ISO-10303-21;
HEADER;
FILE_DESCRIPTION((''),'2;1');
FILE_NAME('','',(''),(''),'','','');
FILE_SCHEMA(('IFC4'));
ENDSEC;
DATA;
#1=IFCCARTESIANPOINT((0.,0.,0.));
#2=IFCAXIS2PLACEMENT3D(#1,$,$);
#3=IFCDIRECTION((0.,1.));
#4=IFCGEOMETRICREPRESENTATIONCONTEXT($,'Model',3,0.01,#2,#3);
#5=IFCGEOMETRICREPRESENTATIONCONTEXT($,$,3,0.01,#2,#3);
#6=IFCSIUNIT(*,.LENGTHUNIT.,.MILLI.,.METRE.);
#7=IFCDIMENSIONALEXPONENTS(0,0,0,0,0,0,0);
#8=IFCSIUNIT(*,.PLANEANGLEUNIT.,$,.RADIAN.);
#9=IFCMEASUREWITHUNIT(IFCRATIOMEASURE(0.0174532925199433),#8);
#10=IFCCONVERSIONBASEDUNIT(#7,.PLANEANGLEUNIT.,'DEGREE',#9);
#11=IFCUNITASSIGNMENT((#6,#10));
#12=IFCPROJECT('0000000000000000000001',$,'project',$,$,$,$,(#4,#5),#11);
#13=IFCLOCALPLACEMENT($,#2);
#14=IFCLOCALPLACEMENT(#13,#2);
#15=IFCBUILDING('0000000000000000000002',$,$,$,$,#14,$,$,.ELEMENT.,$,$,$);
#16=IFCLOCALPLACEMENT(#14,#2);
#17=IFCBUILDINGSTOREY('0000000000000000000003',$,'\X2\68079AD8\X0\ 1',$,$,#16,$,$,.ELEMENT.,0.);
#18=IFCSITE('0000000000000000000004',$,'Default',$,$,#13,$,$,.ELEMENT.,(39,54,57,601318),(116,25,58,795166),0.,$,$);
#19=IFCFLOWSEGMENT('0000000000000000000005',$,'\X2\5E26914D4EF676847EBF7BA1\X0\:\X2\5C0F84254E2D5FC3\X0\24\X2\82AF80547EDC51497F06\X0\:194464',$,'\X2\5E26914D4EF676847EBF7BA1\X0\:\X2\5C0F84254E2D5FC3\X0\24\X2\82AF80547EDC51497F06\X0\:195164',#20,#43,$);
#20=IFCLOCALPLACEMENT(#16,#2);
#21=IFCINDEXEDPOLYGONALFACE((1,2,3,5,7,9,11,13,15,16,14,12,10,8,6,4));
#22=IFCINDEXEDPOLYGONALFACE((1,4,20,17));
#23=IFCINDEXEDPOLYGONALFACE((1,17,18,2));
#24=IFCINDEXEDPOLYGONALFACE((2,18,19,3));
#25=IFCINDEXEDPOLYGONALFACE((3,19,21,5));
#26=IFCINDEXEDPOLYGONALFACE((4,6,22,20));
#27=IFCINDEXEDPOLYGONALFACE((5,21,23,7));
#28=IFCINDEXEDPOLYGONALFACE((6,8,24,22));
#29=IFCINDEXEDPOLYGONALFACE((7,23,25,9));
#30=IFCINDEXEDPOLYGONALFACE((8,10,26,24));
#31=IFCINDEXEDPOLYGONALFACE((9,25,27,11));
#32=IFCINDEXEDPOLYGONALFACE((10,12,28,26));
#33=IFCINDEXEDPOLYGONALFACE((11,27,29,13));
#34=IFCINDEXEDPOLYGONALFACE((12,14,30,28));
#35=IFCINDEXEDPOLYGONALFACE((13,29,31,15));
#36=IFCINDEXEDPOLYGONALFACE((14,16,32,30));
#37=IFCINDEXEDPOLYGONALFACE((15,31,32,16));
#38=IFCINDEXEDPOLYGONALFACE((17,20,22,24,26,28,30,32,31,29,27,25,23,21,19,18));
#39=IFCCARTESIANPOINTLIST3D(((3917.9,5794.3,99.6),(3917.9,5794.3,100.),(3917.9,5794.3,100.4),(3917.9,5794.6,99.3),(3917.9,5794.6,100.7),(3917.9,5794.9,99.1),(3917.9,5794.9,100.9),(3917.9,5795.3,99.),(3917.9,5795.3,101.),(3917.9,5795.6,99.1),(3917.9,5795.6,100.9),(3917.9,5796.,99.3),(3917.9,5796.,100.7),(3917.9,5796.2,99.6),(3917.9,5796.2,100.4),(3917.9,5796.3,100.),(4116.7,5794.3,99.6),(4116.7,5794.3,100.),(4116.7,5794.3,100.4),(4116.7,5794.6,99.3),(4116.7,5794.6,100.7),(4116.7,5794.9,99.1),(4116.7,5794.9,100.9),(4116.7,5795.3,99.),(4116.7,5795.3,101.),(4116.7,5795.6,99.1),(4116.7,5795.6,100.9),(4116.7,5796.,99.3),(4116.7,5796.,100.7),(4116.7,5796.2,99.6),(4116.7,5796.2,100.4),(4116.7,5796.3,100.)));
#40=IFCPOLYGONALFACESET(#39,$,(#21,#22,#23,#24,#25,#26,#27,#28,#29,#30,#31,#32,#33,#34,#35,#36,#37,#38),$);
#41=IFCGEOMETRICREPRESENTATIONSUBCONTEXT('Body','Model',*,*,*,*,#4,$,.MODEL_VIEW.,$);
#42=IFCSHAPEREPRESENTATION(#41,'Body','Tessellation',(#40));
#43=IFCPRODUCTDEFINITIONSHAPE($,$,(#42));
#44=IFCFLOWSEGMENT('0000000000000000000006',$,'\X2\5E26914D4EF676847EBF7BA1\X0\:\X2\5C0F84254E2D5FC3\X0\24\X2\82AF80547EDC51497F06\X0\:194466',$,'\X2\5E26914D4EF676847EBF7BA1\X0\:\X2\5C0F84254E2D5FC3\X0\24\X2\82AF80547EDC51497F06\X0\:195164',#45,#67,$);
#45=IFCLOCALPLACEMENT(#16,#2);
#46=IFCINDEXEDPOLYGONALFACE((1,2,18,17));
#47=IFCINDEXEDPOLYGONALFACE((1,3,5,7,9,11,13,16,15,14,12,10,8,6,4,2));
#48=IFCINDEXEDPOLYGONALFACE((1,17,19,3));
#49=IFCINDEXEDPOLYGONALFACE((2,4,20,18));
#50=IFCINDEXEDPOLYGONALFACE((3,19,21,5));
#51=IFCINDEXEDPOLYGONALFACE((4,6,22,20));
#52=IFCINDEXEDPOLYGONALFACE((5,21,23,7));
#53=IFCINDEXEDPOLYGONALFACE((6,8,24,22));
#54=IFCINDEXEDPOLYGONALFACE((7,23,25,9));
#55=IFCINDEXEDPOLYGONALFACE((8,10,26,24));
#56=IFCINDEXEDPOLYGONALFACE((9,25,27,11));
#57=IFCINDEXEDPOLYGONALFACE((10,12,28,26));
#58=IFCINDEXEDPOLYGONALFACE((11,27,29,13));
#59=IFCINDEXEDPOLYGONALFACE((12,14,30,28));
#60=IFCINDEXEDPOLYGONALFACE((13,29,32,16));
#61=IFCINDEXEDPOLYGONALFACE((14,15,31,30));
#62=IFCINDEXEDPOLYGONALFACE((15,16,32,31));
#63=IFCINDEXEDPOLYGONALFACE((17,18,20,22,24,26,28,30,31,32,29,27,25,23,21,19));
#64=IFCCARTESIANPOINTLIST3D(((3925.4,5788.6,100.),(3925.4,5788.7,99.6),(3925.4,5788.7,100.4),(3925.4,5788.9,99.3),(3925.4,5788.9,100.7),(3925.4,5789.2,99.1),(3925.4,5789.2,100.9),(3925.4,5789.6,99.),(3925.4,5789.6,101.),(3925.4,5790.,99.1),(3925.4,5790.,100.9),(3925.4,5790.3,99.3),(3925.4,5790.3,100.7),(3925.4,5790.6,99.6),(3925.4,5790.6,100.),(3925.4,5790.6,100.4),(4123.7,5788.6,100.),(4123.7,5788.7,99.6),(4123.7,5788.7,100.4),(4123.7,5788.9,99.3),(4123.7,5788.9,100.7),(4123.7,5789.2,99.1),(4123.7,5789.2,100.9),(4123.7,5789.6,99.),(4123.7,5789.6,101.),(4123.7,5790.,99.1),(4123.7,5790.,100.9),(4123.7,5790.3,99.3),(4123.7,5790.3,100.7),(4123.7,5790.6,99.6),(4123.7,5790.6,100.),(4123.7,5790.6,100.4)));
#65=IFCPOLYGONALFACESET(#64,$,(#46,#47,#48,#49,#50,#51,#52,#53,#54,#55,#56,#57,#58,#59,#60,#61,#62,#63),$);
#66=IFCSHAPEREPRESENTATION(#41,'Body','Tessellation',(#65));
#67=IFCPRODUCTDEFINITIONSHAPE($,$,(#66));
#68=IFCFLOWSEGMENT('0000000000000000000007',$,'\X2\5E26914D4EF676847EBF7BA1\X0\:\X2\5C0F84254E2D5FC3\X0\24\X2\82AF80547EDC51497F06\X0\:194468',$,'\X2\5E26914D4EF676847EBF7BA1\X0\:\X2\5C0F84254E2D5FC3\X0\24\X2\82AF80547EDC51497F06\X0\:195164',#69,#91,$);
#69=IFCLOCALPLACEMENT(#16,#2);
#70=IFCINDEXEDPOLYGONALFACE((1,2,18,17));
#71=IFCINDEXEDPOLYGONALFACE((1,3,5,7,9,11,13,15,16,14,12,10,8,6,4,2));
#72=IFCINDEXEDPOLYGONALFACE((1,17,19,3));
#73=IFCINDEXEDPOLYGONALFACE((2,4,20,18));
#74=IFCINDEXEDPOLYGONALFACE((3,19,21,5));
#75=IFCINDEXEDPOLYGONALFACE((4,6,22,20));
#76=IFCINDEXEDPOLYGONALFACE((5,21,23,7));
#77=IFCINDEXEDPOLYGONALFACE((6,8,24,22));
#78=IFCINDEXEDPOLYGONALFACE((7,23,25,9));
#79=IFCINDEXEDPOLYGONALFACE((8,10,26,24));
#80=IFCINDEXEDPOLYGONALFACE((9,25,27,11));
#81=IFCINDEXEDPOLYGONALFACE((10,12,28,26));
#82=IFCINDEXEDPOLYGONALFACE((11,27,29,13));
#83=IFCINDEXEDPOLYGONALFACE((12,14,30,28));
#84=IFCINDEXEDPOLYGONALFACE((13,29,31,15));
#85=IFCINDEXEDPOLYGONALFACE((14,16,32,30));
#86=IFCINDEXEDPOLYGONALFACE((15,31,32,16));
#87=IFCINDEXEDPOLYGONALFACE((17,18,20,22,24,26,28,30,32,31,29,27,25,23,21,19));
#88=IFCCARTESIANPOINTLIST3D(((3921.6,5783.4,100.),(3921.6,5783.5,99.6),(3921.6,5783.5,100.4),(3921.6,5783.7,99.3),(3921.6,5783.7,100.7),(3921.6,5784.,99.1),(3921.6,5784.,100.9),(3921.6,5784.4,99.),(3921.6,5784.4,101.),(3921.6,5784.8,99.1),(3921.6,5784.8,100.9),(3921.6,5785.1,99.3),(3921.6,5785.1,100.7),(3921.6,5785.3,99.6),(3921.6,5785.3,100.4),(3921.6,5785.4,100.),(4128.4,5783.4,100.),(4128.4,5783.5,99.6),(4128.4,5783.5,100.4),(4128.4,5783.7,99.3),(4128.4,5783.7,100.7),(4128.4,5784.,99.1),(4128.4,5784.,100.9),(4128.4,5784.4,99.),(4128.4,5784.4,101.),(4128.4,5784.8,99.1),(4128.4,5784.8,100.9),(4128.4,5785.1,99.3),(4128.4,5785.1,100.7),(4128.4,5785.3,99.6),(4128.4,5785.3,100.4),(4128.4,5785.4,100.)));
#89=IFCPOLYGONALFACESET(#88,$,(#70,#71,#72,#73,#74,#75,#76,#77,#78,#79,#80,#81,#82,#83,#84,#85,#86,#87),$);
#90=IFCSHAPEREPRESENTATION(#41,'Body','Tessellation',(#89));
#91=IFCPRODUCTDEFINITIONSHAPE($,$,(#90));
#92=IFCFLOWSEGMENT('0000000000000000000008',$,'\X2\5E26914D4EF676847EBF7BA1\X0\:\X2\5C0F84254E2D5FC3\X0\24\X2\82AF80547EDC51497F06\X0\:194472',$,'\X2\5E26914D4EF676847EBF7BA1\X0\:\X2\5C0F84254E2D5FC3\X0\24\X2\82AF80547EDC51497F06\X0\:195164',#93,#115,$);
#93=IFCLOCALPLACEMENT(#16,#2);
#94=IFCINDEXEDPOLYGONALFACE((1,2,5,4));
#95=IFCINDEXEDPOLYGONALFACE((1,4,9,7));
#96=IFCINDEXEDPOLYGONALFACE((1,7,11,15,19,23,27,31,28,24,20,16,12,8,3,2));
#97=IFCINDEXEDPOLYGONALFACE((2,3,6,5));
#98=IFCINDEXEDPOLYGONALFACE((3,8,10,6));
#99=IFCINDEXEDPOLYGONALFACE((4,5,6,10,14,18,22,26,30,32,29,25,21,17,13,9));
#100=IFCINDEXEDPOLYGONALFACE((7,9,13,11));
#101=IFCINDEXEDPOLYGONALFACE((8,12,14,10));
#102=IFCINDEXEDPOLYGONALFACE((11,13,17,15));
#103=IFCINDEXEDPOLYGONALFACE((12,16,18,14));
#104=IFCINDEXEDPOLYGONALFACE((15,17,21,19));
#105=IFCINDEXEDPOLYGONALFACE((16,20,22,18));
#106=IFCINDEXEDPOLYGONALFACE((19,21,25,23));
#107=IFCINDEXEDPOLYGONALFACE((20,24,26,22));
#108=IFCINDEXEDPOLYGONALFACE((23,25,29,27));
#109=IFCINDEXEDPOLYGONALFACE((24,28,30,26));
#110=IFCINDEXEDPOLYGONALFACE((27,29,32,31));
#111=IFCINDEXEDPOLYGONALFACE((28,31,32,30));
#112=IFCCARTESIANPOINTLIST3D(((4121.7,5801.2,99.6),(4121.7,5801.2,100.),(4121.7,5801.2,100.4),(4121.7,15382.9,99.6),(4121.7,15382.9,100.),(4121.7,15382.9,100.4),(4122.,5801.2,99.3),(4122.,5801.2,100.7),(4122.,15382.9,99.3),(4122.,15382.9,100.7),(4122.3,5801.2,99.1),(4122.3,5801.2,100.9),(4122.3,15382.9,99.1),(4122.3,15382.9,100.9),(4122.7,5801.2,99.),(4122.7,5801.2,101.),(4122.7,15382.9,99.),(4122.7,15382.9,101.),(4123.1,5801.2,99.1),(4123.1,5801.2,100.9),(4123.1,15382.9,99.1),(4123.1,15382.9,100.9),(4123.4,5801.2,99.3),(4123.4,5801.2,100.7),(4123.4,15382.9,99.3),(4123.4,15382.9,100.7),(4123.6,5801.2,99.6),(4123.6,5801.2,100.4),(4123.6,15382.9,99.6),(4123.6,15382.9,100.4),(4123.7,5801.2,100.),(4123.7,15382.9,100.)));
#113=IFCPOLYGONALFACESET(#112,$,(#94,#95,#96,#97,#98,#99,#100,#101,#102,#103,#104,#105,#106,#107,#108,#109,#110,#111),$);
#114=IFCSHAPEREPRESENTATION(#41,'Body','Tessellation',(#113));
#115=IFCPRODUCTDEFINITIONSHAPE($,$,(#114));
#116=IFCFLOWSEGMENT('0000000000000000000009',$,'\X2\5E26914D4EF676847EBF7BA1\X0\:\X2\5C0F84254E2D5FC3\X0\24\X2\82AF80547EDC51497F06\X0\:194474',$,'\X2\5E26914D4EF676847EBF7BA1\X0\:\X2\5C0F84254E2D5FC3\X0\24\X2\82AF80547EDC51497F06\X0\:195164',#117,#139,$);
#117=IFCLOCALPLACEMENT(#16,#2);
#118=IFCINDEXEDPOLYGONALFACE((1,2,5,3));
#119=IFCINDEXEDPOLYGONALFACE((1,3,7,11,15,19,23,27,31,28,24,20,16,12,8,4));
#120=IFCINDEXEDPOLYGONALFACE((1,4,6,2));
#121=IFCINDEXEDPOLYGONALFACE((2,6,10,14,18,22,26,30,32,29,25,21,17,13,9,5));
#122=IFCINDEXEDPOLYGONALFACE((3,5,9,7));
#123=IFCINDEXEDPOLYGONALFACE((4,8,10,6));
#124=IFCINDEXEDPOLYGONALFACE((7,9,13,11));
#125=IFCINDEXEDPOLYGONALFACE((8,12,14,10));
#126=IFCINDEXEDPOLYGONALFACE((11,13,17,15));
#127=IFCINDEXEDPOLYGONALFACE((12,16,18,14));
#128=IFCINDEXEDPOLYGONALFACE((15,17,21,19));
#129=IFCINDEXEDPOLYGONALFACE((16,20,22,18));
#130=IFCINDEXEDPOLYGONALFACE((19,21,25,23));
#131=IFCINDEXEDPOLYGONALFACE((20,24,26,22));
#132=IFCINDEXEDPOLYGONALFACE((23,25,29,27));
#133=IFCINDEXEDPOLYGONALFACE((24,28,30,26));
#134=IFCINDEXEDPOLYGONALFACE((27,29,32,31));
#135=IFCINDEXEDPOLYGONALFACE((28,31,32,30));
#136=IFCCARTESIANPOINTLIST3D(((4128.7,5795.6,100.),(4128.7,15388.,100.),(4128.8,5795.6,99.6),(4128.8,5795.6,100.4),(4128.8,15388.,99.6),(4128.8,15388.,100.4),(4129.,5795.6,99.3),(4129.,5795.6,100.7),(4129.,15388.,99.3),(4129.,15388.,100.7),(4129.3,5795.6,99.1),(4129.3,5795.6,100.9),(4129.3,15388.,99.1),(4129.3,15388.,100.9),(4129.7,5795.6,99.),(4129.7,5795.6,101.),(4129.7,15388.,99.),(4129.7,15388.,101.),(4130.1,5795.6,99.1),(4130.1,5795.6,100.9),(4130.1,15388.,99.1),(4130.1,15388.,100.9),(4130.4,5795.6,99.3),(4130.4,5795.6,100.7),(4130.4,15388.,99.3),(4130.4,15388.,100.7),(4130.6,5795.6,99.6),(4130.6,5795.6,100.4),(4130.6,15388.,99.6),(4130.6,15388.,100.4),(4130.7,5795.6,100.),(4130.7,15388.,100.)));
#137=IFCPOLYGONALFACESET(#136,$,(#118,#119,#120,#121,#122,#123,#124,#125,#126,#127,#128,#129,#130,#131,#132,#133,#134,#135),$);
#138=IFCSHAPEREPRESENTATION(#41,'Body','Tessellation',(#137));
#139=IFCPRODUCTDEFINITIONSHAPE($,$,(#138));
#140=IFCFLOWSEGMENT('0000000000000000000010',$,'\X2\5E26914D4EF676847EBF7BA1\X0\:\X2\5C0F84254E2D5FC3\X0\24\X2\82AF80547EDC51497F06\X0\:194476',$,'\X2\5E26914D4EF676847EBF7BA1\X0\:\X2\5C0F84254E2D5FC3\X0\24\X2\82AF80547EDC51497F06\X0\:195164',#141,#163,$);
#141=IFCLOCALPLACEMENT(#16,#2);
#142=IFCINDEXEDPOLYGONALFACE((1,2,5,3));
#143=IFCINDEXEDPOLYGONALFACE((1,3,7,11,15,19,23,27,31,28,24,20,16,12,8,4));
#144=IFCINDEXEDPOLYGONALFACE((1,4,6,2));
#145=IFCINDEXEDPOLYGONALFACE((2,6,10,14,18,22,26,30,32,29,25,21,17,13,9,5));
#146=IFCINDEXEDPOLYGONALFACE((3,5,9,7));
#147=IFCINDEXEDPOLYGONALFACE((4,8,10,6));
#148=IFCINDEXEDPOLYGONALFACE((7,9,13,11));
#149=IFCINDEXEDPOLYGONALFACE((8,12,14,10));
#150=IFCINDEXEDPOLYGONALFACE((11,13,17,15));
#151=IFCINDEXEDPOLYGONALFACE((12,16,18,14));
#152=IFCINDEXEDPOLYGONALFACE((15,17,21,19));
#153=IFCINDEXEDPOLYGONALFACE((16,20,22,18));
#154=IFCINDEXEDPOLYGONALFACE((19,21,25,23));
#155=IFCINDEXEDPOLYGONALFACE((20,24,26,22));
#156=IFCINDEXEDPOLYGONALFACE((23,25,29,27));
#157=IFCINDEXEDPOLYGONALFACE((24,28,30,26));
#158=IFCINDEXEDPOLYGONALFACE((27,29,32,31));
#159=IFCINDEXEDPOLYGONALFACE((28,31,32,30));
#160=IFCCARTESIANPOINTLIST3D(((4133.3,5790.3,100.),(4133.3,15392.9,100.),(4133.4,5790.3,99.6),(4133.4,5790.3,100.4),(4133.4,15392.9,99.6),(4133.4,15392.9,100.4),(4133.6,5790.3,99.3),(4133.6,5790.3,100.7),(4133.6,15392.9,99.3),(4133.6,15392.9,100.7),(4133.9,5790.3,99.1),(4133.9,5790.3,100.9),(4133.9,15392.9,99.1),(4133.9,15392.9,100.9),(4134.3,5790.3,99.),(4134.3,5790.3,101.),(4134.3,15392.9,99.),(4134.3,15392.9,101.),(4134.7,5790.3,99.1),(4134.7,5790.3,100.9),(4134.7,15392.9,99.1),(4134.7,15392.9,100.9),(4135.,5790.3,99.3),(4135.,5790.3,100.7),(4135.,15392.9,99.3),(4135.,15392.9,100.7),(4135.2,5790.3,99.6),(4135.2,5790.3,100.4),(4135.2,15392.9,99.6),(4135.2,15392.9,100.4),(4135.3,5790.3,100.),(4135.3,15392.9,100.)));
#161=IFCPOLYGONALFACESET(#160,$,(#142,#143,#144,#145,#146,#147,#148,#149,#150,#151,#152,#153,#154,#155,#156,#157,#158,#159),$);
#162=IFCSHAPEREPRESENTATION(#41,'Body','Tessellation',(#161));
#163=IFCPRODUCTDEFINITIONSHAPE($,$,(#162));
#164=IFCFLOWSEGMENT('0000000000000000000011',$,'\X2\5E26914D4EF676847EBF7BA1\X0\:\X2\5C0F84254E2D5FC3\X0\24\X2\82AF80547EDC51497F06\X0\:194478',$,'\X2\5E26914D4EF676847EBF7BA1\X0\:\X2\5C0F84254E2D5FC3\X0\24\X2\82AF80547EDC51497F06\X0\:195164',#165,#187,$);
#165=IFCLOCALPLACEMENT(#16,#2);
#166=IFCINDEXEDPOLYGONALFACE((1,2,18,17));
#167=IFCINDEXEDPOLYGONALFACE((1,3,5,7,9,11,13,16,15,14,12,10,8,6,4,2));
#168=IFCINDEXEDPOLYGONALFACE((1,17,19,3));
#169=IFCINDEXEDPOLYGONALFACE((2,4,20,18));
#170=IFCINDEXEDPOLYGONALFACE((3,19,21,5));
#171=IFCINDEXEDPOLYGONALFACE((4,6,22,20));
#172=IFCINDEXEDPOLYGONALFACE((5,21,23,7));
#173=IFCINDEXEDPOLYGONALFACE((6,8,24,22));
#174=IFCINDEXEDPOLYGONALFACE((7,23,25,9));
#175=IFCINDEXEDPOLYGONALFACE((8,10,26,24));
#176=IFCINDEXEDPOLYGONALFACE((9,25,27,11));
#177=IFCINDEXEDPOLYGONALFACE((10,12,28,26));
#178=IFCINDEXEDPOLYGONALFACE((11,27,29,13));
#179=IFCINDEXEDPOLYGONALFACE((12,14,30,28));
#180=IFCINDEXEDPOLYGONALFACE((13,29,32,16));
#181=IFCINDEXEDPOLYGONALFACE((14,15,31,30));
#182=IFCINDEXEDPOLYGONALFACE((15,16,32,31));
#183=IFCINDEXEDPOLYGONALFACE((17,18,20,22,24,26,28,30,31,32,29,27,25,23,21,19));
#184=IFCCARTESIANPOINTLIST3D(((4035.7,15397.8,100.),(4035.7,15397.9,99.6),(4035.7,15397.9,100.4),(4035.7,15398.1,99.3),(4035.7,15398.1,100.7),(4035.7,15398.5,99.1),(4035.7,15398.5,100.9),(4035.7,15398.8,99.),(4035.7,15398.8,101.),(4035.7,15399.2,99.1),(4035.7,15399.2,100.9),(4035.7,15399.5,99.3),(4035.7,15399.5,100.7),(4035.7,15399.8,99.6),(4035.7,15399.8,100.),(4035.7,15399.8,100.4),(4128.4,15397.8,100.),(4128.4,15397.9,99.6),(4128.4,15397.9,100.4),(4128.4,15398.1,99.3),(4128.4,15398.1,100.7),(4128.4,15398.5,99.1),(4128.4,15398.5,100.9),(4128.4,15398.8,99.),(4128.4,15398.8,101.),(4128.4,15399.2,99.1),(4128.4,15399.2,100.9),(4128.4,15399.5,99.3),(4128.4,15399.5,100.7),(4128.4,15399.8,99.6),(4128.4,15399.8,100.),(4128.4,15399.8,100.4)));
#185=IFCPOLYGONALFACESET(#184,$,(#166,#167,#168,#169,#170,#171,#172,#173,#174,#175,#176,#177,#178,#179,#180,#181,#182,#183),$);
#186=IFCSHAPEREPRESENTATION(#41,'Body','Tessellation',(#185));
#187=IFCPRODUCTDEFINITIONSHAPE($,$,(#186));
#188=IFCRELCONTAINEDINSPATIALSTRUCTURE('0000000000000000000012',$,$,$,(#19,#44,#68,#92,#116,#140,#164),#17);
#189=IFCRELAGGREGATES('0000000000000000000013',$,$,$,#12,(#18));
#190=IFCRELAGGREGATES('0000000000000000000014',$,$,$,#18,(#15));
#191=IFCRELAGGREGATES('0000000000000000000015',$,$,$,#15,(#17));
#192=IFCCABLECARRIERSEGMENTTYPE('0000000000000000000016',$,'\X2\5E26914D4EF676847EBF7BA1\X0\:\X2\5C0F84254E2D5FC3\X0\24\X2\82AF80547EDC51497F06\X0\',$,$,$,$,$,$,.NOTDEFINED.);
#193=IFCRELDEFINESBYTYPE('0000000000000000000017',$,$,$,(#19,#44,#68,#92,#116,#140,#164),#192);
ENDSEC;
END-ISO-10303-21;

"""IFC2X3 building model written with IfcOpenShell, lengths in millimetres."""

from ifc_helpers import new_model, entity, si_unit, converted_unit, direction, frame, frame_2d, origin, origin_2d_with_axis, place, context, subcontext, project, spatial, circle, extrude, type_object, element, save


model = new_model("IFC2X3")

# Units and contexts
model_context = context("Model", 3, precision=0.01, world=origin(), true_north=direction((0.0, 1.0)))
context_of_model = context(None, 3, precision=0.01, world=origin(), true_north=direction((0.0, 1.0)))
body_context = subcontext(model_context, "Body", "Model", "MODEL_VIEW")
ifc_project = project(units=[si_unit("LENGTHUNIT", "METRE", prefix="MILLI"), converted_unit("PLANEANGLEUNIT", "DEGREE", entity("IfcRatioMeasure", 0.0174532925199433), si_unit("PLANEANGLEUNIT", "RADIAN"), dimensions=[0, 0, 0, 0, 0, 0, 0])], contexts=[model_context, context_of_model])

# Site, building, storey
site_placement = place(None, origin())
site = spatial("IfcSite", under=ifc_project, at=site_placement, Name="Default", CompositionType="ELEMENT", RefLatitude=(39, 54, 57, 601318), RefLongitude=(116, 25, 58, 795166), RefElevation=0.0)
building_placement = place(site_placement, origin())
building = spatial("IfcBuilding", under=site, at=building_placement, CompositionType="ELEMENT")
storey_placement = place(building_placement, origin())
storey = spatial("IfcBuildingStorey", under=building, at=storey_placement, Name="标高 1", CompositionType="ELEMENT", Elevation=0.0)

# Flow segments
cable_carrier_segment_type = type_object("IfcCableCarrierSegmentType", Name="带配件的线管:小营中心24芯联络光缆", PredefinedType="NOTDEFINED")
flow_segment_1_placement = place(storey_placement, origin())
element("IfcFlowSegment", 1, at=flow_segment_1_placement, inside=storey, type_object=cable_carrier_segment_type, Name="带配件的线管:小营中心24芯联络光缆:194464", ObjectType="带配件的线管:小营中心24芯联络光缆:195164", context=body_context, shape_type="SweptSolid", body=[
    extrude(circle(Radius=1.0, at=origin_2d_with_axis()), frame((3917.9, 5795.3, 100.0), z_axis=(1.0, 0.0, 0.0), x_axis=(0.0, -1.0, 0.0)), (0.0, 0.0, 1.0), 198.8),
])
flow_segment_2_placement = place(storey_placement, origin())
element("IfcFlowSegment", 2, at=flow_segment_2_placement, inside=storey, type_object=cable_carrier_segment_type, Name="带配件的线管:小营中心24芯联络光缆:194466", ObjectType="带配件的线管:小营中心24芯联络光缆:195164", context=body_context, shape_type="SweptSolid", body=[
    extrude(circle(Radius=1.0, at=origin_2d_with_axis()), frame((3925.4, 5789.6, 100.0), z_axis=(1.0, 0.0, 0.0), x_axis=(0.0, -1.0, 0.0)), (0.0, 0.0, 1.0), 198.4),
])
flow_segment_3_placement = place(storey_placement, origin())
element("IfcFlowSegment", 3, at=flow_segment_3_placement, inside=storey, type_object=cable_carrier_segment_type, Name="带配件的线管:小营中心24芯联络光缆:194468", ObjectType="带配件的线管:小营中心24芯联络光缆:195164", context=body_context, shape_type="SweptSolid", body=[
    extrude(circle(Radius=1.0, at=frame_2d((0.0, 0.0), x_axis=(1.0, 0.0))), frame((3921.6, 5784.4, 100.0), z_axis=(1.0, 0.0, 0.0), x_axis=(0.0, 1.0, 0.0)), (0.0, 0.0, 1.0), 206.8),
])
flow_segment_4_placement = place(storey_placement, origin())
element("IfcFlowSegment", 4, at=flow_segment_4_placement, inside=storey, type_object=cable_carrier_segment_type, Name="带配件的线管:小营中心24芯联络光缆:194472", ObjectType="带配件的线管:小营中心24芯联络光缆:195164", context=body_context, shape_type="SweptSolid", body=[
    extrude(circle(Radius=1.0, at=frame_2d((0.0, 0.0), x_axis=(1.0, 0.0))), frame((4122.7, 5801.2, 100.0), z_axis=(0.0, 1.0, 0.0), x_axis=(-1.0, 0.0, 0.0)), (0.0, 0.0, 1.0), 9581.7),
])
flow_segment_5_placement = place(storey_placement, origin())
element("IfcFlowSegment", 5, at=flow_segment_5_placement, inside=storey, type_object=cable_carrier_segment_type, Name="带配件的线管:小营中心24芯联络光缆:194474", ObjectType="带配件的线管:小营中心24芯联络光缆:195164", context=body_context, shape_type="SweptSolid", body=[
    extrude(circle(Radius=1.0, at=frame_2d((0.0, 0.0), x_axis=(1.0, 0.0))), frame((4129.7, 5795.6, 100.0), z_axis=(0.0, 1.0, 0.0), x_axis=(-1.0, 0.0, 0.0)), (0.0, 0.0, 1.0), 9592.4),
])
flow_segment_6_placement = place(storey_placement, origin())
element("IfcFlowSegment", 6, at=flow_segment_6_placement, inside=storey, type_object=cable_carrier_segment_type, Name="带配件的线管:小营中心24芯联络光缆:194476", ObjectType="带配件的线管:小营中心24芯联络光缆:195164", context=body_context, shape_type="SweptSolid", body=[
    extrude(circle(Radius=1.0, at=frame_2d((0.0, 0.0), x_axis=(1.0, 0.0))), frame((4134.3, 5790.3, 100.0), z_axis=(0.0, 1.0, 0.0), x_axis=(-1.0, 0.0, 0.0)), (0.0, 0.0, 1.0), 9602.5),
])
flow_segment_7_placement = place(storey_placement, origin())
element("IfcFlowSegment", 7, at=flow_segment_7_placement, inside=storey, type_object=cable_carrier_segment_type, Name="带配件的线管:小营中心24芯联络光缆:194478", ObjectType="带配件的线管:小营中心24芯联络光缆:195164", context=body_context, shape_type="SweptSolid", body=[
    extrude(circle(Radius=1.0, at=origin_2d_with_axis()), frame((4035.7, 15398.8, 100.0), z_axis=(1.0, 0.0, 0.0), x_axis=(0.0, -1.0, 0.0)), (0.0, 0.0, 1.0), 92.7),
])

save(model, "model.ifc")
